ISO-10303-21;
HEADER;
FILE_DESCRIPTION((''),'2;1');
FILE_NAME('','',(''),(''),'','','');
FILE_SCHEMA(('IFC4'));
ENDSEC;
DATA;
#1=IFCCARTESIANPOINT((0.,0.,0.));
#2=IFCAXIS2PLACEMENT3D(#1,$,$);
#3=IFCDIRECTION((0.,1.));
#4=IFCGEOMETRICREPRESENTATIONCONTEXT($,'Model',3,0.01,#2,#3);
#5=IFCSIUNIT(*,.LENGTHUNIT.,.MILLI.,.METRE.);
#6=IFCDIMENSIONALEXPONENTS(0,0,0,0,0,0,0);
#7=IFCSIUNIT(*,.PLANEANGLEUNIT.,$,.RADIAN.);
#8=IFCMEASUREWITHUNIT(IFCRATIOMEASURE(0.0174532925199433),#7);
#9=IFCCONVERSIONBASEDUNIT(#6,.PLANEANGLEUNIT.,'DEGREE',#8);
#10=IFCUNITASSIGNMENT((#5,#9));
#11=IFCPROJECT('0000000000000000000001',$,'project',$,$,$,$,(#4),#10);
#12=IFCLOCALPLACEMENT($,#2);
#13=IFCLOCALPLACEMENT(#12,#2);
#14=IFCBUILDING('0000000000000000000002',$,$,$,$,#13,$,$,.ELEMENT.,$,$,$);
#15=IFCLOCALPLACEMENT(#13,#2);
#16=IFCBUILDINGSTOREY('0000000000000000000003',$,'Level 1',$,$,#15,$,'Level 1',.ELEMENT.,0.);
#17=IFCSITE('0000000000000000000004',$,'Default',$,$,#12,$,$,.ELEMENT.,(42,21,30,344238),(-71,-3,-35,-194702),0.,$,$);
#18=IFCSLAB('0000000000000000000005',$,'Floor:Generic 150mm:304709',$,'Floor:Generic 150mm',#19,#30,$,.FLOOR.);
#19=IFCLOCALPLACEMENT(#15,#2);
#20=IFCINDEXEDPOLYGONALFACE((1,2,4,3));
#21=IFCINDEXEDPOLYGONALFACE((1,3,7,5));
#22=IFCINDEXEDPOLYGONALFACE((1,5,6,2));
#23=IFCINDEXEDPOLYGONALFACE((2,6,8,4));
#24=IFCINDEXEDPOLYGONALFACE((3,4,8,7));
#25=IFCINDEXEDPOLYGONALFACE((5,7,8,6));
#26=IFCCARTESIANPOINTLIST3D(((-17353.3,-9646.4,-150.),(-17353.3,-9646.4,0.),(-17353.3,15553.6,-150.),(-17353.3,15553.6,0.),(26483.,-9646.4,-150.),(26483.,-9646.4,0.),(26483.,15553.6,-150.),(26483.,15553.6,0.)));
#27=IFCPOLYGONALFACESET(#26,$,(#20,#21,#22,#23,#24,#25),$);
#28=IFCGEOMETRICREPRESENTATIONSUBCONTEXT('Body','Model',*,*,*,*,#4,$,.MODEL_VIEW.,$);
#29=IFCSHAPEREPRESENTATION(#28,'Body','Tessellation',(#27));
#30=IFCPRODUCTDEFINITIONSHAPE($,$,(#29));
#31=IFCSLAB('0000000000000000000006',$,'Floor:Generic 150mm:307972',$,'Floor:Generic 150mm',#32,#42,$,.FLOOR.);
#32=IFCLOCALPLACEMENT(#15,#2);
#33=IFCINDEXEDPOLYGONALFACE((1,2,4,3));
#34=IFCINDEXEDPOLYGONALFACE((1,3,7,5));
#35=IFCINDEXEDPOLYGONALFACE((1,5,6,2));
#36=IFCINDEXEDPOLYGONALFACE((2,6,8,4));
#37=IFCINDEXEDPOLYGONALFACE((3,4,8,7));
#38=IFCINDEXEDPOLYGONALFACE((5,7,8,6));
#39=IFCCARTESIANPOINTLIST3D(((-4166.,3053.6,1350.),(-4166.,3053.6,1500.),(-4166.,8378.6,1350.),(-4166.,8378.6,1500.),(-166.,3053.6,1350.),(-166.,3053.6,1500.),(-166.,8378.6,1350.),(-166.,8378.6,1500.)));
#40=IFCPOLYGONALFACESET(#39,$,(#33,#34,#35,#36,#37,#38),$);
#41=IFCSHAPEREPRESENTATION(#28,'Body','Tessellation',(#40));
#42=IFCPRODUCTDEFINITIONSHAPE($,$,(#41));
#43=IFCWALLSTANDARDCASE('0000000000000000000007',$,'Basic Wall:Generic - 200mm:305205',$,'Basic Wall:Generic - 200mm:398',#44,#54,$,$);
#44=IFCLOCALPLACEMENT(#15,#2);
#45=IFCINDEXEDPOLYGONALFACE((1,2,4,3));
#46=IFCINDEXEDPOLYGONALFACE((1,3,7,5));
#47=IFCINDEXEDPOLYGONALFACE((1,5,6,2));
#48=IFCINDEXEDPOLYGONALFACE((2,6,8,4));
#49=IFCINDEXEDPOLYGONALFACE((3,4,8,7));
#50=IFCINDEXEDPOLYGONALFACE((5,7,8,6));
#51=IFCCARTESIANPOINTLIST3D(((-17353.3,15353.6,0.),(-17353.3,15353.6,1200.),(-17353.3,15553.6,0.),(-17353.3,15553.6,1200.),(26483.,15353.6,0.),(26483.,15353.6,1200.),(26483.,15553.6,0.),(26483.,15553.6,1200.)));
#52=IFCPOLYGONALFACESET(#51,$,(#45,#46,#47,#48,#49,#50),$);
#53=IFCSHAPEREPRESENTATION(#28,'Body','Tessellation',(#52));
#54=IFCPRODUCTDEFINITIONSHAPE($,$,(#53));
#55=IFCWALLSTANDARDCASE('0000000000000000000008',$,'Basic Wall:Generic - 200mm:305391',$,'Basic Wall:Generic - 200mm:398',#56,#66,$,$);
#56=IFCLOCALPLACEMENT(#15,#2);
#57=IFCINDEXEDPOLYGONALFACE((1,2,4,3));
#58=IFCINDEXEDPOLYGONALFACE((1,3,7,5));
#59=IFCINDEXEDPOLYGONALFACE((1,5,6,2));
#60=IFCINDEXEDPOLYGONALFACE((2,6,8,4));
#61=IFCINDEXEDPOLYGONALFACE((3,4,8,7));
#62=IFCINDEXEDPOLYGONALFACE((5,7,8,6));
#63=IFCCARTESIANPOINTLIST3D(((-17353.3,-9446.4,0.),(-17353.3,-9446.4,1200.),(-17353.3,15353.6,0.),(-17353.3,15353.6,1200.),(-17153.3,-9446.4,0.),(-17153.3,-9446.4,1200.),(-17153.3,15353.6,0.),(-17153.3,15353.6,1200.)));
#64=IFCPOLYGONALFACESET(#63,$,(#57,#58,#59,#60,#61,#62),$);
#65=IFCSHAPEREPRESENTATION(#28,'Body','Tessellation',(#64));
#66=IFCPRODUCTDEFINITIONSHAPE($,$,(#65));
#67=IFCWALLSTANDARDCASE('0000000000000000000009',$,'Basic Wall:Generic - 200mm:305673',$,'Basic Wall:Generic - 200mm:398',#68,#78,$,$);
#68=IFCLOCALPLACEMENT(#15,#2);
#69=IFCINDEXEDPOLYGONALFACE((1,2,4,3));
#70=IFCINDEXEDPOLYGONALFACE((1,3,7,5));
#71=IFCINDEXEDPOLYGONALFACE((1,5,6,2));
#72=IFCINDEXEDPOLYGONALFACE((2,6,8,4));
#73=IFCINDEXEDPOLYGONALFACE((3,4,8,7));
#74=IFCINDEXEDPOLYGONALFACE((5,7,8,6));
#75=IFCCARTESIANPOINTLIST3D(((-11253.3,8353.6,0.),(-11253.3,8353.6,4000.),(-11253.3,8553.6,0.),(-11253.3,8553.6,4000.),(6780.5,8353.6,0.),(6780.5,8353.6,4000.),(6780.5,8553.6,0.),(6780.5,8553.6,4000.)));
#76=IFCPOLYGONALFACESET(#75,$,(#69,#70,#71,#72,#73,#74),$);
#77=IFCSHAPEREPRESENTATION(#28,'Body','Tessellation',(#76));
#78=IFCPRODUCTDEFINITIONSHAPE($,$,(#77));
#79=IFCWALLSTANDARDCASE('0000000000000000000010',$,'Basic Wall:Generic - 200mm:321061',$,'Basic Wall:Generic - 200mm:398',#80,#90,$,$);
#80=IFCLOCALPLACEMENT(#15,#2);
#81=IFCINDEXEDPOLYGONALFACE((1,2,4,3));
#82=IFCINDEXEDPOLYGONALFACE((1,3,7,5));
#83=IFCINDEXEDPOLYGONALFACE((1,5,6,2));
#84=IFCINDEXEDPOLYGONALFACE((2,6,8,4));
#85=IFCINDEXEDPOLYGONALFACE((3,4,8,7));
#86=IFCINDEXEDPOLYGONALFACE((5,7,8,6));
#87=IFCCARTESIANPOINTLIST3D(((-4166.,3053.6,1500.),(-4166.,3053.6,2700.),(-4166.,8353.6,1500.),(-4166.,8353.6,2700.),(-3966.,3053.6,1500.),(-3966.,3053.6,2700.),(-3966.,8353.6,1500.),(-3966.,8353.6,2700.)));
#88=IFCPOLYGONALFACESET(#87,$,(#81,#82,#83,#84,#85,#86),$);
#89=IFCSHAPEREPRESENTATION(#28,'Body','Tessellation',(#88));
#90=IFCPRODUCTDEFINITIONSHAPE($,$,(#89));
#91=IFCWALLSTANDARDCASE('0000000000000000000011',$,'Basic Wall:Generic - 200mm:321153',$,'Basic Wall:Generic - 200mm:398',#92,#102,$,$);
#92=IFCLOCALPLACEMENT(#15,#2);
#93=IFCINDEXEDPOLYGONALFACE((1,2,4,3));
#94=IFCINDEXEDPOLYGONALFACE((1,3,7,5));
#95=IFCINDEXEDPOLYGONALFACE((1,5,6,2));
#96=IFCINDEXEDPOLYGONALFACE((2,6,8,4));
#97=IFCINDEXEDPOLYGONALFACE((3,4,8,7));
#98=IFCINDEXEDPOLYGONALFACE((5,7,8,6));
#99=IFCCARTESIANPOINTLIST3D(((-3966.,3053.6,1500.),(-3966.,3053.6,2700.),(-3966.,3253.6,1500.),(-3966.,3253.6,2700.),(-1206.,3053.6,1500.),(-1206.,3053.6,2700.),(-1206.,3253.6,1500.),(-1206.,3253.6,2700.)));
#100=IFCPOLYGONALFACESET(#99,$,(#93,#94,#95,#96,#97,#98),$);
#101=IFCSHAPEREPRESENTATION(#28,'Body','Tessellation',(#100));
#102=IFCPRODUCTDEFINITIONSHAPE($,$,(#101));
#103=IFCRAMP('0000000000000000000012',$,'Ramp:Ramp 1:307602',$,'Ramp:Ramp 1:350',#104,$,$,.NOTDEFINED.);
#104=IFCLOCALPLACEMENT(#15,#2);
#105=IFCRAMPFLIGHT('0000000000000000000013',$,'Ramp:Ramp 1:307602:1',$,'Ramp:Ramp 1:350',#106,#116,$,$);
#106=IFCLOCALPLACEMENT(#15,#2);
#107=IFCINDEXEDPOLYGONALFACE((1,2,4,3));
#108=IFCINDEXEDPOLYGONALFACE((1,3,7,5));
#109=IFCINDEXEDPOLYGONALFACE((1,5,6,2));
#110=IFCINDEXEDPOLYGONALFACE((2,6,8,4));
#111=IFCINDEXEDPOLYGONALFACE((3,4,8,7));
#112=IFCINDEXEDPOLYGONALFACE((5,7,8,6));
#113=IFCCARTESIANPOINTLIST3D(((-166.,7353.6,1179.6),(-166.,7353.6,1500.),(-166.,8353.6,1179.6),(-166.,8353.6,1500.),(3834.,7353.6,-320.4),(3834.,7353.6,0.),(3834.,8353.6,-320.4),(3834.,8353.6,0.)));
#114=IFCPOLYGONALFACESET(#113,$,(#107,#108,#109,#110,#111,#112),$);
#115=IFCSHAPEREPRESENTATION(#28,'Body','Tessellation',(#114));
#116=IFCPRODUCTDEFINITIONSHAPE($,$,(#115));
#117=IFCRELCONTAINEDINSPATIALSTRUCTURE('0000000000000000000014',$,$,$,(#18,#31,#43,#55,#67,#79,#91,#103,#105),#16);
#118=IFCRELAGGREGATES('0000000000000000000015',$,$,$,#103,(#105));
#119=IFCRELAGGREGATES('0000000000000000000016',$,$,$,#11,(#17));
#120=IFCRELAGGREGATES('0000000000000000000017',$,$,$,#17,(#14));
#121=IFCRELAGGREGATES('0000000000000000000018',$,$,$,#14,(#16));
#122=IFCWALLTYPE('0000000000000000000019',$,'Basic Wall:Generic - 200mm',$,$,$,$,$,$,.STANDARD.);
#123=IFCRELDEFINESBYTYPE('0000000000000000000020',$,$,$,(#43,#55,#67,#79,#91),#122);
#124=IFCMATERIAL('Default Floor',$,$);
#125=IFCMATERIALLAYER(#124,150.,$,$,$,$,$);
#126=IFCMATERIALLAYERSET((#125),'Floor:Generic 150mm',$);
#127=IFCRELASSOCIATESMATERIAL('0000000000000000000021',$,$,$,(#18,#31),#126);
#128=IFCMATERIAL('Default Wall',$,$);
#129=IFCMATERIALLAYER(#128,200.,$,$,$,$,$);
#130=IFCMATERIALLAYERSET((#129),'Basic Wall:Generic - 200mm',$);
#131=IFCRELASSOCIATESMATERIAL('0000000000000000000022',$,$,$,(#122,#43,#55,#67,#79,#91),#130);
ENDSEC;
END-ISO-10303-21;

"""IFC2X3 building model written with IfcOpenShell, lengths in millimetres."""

from ifc_helpers import new_model, entity, si_unit, converted_unit, direction, frame, frame_2d, origin, place, context, subcontext, project, spatial, polyline, rectangle, outline, extrude, clip, halfspace, material, layer, layer_set, layer_usage, type_object, element, aggregate, save


model = new_model("IFC2X3")

# Units and contexts
model_context = context("Model", 3, precision=0.01, world=origin(), true_north=direction((0.0, 1.0)))
body_context = subcontext(model_context, "Body", "Model", "MODEL_VIEW")
ifc_project = project(units=[si_unit("LENGTHUNIT", "METRE", prefix="MILLI"), converted_unit("PLANEANGLEUNIT", "DEGREE", entity("IfcRatioMeasure", 0.0174532925199433), si_unit("PLANEANGLEUNIT", "RADIAN"), dimensions=[0, 0, 0, 0, 0, 0, 0])], contexts=[model_context])

# Site, building, storey
site_placement = place(None, origin())
site = spatial("IfcSite", under=ifc_project, at=site_placement, Name="Default", CompositionType="ELEMENT", RefLatitude=(42, 21, 30, 344238), RefLongitude=(-71, -3, -35, -194702), RefElevation=0.0)
building_placement = place(site_placement, origin())
building = spatial("IfcBuilding", under=site, at=building_placement, CompositionType="ELEMENT")
storey_placement = place(building_placement, origin())
storey = spatial("IfcBuildingStorey", under=building, at=storey_placement, Name="Level 1", LongName="Level 1", CompositionType="ELEMENT", Elevation=0.0)

# Slabs
ifc_material_1 = material(Name="Default Floor")
ifc_layer_1 = layer(ifc_material_1, 150.0)
ifc_layer_set_1 = layer_set([ifc_layer_1], Name="Floor:Generic 150mm")
ifc_layer_usage_1 = layer_usage(ifc_layer_set_1, "AXIS3", "POSITIVE", 0.0)
slab_1_placement = place(storey_placement, origin())
element("IfcSlab", 1, at=slab_1_placement, inside=storey, material=ifc_layer_usage_1, Name="Floor:Generic 150mm:304709", ObjectType="Floor:Generic 150mm", PredefinedType="FLOOR", context=body_context, shape_type="SweptSolid", body=[
    extrude(rectangle(XDim=25200.0, YDim=43836.3, at=frame_2d((0.0, 0.0), x_axis=(1.0, 0.0))), frame((4564.9, 2953.6, 0.0), z_axis=(0.0, 0.0, -1.0), x_axis=(0.0, 1.0, 0.0)), (0.0, 0.0, 1.0), 150.0),
])
ifc_layer_usage_2 = layer_usage(ifc_layer_set_1, "AXIS3", "POSITIVE", 0.0)
slab_2_placement = place(storey_placement, origin())
element("IfcSlab", 2, at=slab_2_placement, inside=storey, material=ifc_layer_usage_2, Name="Floor:Generic 150mm:307972", ObjectType="Floor:Generic 150mm", PredefinedType="FLOOR", context=body_context, shape_type="SweptSolid", body=[
    extrude(rectangle(XDim=5325.0, YDim=4000.0, at=frame_2d((0.0, 0.0), x_axis=(1.0, 0.0))), frame((-2166.0, 5716.1, 1500.0), z_axis=(0.0, 0.0, -1.0), x_axis=(0.0, 1.0, 0.0)), (0.0, 0.0, 1.0), 150.0),
])

# Walls
ifc_material_2 = material(Name="Default Wall")
ifc_layer_2 = layer(ifc_material_2, 200.0)
ifc_layer_set_2 = layer_set([ifc_layer_2], Name="Basic Wall:Generic - 200mm")
ifc_layer_usage_3 = layer_usage(ifc_layer_set_2, "AXIS2", "NEGATIVE", 100.0)
wall_type = type_object("IfcWallType", Name="Basic Wall:Generic - 200mm", PredefinedType="STANDARD", material=ifc_layer_set_2)
wall_1_placement = place(storey_placement, frame((-17353.3, 15453.6, 0.0)))
element("IfcWallStandardCase", 3, at=wall_1_placement, inside=storey, type_object=wall_type, material=ifc_layer_usage_3, Name="Basic Wall:Generic - 200mm:305205", ObjectType="Basic Wall:Generic - 200mm:398", context=body_context, shape_type="SweptSolid", body=[
    extrude(rectangle(XDim=43836.3, YDim=200.0, at=frame_2d((21918.1, 0.0), x_axis=(-1.0, 0.0))), origin(), (0.0, 0.0, 1.0), 1200.0),
])
ifc_layer_usage_4 = layer_usage(ifc_layer_set_2, "AXIS2", "NEGATIVE", 100.0)
wall_2_placement = place(storey_placement, frame((-17253.3, -9446.4, 0.0), z_axis=(0.0, 0.0, 1.0), x_axis=(0.0, 1.0, 0.0)))
element("IfcWallStandardCase", 4, at=wall_2_placement, inside=storey, type_object=wall_type, material=ifc_layer_usage_4, Name="Basic Wall:Generic - 200mm:305391", ObjectType="Basic Wall:Generic - 200mm:398", context=body_context, shape_type="SweptSolid", body=[
    extrude(rectangle(XDim=24800.0, YDim=200.0, at=frame_2d((12400.0, 0.0), x_axis=(-1.0, 0.0))), origin(), (0.0, 0.0, 1.0), 1200.0),
])
ifc_layer_usage_5 = layer_usage(ifc_layer_set_2, "AXIS2", "NEGATIVE", 100.0)
wall_3_placement = place(storey_placement, frame((-11253.3, 8453.6, 0.0)))
element("IfcWallStandardCase", 5, at=wall_3_placement, inside=storey, type_object=wall_type, material=ifc_layer_usage_5, Name="Basic Wall:Generic - 200mm:305673", ObjectType="Basic Wall:Generic - 200mm:398", context=body_context, shape_type="Clipping", body=[
    clip(extrude(rectangle(XDim=18033.8, YDim=200.0, at=frame_2d((9016.9, 0.0), x_axis=(-1.0, 0.0))), origin(), (0.0, 0.0, 1.0), 4000.0), halfspace(origin(), True)),
])

# Walls
ifc_layer_usage_6 = layer_usage(ifc_layer_set_2, "AXIS2", "NEGATIVE", 100.0)
wall_4_placement = place(storey_placement, frame((-4066.0, 8353.6, 1500.0), z_axis=(0.0, 0.0, 1.0), x_axis=(0.0, -1.0, 0.0)))
element("IfcWallStandardCase", 6, at=wall_4_placement, inside=storey, type_object=wall_type, material=ifc_layer_usage_6, Name="Basic Wall:Generic - 200mm:321061", ObjectType="Basic Wall:Generic - 200mm:398", context=body_context, shape_type="SweptSolid", body=[
    extrude(rectangle(XDim=5300.0, YDim=200.0, at=frame_2d((2650.0, 0.0), x_axis=(-1.0, 0.0))), origin(), (0.0, 0.0, 1.0), 1200.0),
])
ifc_layer_usage_7 = layer_usage(ifc_layer_set_2, "AXIS2", "NEGATIVE", 100.0)
wall_5_placement = place(storey_placement, frame((-3966.0, 3153.6, 1500.0)))
element("IfcWallStandardCase", 7, at=wall_5_placement, inside=storey, type_object=wall_type, material=ifc_layer_usage_7, Name="Basic Wall:Generic - 200mm:321153", ObjectType="Basic Wall:Generic - 200mm:398", context=body_context, shape_type="SweptSolid", body=[
    extrude(rectangle(XDim=2760.0, YDim=200.0, at=frame_2d((1380.0, 0.0), x_axis=(-1.0, 0.0))), origin(), (0.0, 0.0, 1.0), 1200.0),
])

# Ramp, ramp flight
ramp_placement = place(storey_placement, origin())
ramp = element("IfcRamp", 8, at=ramp_placement, inside=storey, Name="Ramp:Ramp 1:307602", ObjectType="Ramp:Ramp 1:350", ShapeType="NOTDEFINED")
ramp_flight_placement = place(ramp_placement, origin())
ramp_flight = element("IfcRampFlight", 9, at=ramp_flight_placement, inside=storey, Name="Ramp:Ramp 1:307602:1", ObjectType="Ramp:Ramp 1:350", context=body_context, shape_type="SweptSolid", body=[
    extrude(outline(polyline([(589.8, -2000.0), (910.2, -2000.0), (-589.8, 2000.0), (-910.2, 2000.0), (589.8, -2000.0)])), frame((1834.0, 7353.6, 589.8), z_axis=(0.0, 1.0, 0.0), x_axis=(0.0, 0.0, -1.0)), (0.0, 0.0, 1.0), 1000.0),
])
aggregate(ramp, [ramp_flight])

save(model, "model.ifc")
